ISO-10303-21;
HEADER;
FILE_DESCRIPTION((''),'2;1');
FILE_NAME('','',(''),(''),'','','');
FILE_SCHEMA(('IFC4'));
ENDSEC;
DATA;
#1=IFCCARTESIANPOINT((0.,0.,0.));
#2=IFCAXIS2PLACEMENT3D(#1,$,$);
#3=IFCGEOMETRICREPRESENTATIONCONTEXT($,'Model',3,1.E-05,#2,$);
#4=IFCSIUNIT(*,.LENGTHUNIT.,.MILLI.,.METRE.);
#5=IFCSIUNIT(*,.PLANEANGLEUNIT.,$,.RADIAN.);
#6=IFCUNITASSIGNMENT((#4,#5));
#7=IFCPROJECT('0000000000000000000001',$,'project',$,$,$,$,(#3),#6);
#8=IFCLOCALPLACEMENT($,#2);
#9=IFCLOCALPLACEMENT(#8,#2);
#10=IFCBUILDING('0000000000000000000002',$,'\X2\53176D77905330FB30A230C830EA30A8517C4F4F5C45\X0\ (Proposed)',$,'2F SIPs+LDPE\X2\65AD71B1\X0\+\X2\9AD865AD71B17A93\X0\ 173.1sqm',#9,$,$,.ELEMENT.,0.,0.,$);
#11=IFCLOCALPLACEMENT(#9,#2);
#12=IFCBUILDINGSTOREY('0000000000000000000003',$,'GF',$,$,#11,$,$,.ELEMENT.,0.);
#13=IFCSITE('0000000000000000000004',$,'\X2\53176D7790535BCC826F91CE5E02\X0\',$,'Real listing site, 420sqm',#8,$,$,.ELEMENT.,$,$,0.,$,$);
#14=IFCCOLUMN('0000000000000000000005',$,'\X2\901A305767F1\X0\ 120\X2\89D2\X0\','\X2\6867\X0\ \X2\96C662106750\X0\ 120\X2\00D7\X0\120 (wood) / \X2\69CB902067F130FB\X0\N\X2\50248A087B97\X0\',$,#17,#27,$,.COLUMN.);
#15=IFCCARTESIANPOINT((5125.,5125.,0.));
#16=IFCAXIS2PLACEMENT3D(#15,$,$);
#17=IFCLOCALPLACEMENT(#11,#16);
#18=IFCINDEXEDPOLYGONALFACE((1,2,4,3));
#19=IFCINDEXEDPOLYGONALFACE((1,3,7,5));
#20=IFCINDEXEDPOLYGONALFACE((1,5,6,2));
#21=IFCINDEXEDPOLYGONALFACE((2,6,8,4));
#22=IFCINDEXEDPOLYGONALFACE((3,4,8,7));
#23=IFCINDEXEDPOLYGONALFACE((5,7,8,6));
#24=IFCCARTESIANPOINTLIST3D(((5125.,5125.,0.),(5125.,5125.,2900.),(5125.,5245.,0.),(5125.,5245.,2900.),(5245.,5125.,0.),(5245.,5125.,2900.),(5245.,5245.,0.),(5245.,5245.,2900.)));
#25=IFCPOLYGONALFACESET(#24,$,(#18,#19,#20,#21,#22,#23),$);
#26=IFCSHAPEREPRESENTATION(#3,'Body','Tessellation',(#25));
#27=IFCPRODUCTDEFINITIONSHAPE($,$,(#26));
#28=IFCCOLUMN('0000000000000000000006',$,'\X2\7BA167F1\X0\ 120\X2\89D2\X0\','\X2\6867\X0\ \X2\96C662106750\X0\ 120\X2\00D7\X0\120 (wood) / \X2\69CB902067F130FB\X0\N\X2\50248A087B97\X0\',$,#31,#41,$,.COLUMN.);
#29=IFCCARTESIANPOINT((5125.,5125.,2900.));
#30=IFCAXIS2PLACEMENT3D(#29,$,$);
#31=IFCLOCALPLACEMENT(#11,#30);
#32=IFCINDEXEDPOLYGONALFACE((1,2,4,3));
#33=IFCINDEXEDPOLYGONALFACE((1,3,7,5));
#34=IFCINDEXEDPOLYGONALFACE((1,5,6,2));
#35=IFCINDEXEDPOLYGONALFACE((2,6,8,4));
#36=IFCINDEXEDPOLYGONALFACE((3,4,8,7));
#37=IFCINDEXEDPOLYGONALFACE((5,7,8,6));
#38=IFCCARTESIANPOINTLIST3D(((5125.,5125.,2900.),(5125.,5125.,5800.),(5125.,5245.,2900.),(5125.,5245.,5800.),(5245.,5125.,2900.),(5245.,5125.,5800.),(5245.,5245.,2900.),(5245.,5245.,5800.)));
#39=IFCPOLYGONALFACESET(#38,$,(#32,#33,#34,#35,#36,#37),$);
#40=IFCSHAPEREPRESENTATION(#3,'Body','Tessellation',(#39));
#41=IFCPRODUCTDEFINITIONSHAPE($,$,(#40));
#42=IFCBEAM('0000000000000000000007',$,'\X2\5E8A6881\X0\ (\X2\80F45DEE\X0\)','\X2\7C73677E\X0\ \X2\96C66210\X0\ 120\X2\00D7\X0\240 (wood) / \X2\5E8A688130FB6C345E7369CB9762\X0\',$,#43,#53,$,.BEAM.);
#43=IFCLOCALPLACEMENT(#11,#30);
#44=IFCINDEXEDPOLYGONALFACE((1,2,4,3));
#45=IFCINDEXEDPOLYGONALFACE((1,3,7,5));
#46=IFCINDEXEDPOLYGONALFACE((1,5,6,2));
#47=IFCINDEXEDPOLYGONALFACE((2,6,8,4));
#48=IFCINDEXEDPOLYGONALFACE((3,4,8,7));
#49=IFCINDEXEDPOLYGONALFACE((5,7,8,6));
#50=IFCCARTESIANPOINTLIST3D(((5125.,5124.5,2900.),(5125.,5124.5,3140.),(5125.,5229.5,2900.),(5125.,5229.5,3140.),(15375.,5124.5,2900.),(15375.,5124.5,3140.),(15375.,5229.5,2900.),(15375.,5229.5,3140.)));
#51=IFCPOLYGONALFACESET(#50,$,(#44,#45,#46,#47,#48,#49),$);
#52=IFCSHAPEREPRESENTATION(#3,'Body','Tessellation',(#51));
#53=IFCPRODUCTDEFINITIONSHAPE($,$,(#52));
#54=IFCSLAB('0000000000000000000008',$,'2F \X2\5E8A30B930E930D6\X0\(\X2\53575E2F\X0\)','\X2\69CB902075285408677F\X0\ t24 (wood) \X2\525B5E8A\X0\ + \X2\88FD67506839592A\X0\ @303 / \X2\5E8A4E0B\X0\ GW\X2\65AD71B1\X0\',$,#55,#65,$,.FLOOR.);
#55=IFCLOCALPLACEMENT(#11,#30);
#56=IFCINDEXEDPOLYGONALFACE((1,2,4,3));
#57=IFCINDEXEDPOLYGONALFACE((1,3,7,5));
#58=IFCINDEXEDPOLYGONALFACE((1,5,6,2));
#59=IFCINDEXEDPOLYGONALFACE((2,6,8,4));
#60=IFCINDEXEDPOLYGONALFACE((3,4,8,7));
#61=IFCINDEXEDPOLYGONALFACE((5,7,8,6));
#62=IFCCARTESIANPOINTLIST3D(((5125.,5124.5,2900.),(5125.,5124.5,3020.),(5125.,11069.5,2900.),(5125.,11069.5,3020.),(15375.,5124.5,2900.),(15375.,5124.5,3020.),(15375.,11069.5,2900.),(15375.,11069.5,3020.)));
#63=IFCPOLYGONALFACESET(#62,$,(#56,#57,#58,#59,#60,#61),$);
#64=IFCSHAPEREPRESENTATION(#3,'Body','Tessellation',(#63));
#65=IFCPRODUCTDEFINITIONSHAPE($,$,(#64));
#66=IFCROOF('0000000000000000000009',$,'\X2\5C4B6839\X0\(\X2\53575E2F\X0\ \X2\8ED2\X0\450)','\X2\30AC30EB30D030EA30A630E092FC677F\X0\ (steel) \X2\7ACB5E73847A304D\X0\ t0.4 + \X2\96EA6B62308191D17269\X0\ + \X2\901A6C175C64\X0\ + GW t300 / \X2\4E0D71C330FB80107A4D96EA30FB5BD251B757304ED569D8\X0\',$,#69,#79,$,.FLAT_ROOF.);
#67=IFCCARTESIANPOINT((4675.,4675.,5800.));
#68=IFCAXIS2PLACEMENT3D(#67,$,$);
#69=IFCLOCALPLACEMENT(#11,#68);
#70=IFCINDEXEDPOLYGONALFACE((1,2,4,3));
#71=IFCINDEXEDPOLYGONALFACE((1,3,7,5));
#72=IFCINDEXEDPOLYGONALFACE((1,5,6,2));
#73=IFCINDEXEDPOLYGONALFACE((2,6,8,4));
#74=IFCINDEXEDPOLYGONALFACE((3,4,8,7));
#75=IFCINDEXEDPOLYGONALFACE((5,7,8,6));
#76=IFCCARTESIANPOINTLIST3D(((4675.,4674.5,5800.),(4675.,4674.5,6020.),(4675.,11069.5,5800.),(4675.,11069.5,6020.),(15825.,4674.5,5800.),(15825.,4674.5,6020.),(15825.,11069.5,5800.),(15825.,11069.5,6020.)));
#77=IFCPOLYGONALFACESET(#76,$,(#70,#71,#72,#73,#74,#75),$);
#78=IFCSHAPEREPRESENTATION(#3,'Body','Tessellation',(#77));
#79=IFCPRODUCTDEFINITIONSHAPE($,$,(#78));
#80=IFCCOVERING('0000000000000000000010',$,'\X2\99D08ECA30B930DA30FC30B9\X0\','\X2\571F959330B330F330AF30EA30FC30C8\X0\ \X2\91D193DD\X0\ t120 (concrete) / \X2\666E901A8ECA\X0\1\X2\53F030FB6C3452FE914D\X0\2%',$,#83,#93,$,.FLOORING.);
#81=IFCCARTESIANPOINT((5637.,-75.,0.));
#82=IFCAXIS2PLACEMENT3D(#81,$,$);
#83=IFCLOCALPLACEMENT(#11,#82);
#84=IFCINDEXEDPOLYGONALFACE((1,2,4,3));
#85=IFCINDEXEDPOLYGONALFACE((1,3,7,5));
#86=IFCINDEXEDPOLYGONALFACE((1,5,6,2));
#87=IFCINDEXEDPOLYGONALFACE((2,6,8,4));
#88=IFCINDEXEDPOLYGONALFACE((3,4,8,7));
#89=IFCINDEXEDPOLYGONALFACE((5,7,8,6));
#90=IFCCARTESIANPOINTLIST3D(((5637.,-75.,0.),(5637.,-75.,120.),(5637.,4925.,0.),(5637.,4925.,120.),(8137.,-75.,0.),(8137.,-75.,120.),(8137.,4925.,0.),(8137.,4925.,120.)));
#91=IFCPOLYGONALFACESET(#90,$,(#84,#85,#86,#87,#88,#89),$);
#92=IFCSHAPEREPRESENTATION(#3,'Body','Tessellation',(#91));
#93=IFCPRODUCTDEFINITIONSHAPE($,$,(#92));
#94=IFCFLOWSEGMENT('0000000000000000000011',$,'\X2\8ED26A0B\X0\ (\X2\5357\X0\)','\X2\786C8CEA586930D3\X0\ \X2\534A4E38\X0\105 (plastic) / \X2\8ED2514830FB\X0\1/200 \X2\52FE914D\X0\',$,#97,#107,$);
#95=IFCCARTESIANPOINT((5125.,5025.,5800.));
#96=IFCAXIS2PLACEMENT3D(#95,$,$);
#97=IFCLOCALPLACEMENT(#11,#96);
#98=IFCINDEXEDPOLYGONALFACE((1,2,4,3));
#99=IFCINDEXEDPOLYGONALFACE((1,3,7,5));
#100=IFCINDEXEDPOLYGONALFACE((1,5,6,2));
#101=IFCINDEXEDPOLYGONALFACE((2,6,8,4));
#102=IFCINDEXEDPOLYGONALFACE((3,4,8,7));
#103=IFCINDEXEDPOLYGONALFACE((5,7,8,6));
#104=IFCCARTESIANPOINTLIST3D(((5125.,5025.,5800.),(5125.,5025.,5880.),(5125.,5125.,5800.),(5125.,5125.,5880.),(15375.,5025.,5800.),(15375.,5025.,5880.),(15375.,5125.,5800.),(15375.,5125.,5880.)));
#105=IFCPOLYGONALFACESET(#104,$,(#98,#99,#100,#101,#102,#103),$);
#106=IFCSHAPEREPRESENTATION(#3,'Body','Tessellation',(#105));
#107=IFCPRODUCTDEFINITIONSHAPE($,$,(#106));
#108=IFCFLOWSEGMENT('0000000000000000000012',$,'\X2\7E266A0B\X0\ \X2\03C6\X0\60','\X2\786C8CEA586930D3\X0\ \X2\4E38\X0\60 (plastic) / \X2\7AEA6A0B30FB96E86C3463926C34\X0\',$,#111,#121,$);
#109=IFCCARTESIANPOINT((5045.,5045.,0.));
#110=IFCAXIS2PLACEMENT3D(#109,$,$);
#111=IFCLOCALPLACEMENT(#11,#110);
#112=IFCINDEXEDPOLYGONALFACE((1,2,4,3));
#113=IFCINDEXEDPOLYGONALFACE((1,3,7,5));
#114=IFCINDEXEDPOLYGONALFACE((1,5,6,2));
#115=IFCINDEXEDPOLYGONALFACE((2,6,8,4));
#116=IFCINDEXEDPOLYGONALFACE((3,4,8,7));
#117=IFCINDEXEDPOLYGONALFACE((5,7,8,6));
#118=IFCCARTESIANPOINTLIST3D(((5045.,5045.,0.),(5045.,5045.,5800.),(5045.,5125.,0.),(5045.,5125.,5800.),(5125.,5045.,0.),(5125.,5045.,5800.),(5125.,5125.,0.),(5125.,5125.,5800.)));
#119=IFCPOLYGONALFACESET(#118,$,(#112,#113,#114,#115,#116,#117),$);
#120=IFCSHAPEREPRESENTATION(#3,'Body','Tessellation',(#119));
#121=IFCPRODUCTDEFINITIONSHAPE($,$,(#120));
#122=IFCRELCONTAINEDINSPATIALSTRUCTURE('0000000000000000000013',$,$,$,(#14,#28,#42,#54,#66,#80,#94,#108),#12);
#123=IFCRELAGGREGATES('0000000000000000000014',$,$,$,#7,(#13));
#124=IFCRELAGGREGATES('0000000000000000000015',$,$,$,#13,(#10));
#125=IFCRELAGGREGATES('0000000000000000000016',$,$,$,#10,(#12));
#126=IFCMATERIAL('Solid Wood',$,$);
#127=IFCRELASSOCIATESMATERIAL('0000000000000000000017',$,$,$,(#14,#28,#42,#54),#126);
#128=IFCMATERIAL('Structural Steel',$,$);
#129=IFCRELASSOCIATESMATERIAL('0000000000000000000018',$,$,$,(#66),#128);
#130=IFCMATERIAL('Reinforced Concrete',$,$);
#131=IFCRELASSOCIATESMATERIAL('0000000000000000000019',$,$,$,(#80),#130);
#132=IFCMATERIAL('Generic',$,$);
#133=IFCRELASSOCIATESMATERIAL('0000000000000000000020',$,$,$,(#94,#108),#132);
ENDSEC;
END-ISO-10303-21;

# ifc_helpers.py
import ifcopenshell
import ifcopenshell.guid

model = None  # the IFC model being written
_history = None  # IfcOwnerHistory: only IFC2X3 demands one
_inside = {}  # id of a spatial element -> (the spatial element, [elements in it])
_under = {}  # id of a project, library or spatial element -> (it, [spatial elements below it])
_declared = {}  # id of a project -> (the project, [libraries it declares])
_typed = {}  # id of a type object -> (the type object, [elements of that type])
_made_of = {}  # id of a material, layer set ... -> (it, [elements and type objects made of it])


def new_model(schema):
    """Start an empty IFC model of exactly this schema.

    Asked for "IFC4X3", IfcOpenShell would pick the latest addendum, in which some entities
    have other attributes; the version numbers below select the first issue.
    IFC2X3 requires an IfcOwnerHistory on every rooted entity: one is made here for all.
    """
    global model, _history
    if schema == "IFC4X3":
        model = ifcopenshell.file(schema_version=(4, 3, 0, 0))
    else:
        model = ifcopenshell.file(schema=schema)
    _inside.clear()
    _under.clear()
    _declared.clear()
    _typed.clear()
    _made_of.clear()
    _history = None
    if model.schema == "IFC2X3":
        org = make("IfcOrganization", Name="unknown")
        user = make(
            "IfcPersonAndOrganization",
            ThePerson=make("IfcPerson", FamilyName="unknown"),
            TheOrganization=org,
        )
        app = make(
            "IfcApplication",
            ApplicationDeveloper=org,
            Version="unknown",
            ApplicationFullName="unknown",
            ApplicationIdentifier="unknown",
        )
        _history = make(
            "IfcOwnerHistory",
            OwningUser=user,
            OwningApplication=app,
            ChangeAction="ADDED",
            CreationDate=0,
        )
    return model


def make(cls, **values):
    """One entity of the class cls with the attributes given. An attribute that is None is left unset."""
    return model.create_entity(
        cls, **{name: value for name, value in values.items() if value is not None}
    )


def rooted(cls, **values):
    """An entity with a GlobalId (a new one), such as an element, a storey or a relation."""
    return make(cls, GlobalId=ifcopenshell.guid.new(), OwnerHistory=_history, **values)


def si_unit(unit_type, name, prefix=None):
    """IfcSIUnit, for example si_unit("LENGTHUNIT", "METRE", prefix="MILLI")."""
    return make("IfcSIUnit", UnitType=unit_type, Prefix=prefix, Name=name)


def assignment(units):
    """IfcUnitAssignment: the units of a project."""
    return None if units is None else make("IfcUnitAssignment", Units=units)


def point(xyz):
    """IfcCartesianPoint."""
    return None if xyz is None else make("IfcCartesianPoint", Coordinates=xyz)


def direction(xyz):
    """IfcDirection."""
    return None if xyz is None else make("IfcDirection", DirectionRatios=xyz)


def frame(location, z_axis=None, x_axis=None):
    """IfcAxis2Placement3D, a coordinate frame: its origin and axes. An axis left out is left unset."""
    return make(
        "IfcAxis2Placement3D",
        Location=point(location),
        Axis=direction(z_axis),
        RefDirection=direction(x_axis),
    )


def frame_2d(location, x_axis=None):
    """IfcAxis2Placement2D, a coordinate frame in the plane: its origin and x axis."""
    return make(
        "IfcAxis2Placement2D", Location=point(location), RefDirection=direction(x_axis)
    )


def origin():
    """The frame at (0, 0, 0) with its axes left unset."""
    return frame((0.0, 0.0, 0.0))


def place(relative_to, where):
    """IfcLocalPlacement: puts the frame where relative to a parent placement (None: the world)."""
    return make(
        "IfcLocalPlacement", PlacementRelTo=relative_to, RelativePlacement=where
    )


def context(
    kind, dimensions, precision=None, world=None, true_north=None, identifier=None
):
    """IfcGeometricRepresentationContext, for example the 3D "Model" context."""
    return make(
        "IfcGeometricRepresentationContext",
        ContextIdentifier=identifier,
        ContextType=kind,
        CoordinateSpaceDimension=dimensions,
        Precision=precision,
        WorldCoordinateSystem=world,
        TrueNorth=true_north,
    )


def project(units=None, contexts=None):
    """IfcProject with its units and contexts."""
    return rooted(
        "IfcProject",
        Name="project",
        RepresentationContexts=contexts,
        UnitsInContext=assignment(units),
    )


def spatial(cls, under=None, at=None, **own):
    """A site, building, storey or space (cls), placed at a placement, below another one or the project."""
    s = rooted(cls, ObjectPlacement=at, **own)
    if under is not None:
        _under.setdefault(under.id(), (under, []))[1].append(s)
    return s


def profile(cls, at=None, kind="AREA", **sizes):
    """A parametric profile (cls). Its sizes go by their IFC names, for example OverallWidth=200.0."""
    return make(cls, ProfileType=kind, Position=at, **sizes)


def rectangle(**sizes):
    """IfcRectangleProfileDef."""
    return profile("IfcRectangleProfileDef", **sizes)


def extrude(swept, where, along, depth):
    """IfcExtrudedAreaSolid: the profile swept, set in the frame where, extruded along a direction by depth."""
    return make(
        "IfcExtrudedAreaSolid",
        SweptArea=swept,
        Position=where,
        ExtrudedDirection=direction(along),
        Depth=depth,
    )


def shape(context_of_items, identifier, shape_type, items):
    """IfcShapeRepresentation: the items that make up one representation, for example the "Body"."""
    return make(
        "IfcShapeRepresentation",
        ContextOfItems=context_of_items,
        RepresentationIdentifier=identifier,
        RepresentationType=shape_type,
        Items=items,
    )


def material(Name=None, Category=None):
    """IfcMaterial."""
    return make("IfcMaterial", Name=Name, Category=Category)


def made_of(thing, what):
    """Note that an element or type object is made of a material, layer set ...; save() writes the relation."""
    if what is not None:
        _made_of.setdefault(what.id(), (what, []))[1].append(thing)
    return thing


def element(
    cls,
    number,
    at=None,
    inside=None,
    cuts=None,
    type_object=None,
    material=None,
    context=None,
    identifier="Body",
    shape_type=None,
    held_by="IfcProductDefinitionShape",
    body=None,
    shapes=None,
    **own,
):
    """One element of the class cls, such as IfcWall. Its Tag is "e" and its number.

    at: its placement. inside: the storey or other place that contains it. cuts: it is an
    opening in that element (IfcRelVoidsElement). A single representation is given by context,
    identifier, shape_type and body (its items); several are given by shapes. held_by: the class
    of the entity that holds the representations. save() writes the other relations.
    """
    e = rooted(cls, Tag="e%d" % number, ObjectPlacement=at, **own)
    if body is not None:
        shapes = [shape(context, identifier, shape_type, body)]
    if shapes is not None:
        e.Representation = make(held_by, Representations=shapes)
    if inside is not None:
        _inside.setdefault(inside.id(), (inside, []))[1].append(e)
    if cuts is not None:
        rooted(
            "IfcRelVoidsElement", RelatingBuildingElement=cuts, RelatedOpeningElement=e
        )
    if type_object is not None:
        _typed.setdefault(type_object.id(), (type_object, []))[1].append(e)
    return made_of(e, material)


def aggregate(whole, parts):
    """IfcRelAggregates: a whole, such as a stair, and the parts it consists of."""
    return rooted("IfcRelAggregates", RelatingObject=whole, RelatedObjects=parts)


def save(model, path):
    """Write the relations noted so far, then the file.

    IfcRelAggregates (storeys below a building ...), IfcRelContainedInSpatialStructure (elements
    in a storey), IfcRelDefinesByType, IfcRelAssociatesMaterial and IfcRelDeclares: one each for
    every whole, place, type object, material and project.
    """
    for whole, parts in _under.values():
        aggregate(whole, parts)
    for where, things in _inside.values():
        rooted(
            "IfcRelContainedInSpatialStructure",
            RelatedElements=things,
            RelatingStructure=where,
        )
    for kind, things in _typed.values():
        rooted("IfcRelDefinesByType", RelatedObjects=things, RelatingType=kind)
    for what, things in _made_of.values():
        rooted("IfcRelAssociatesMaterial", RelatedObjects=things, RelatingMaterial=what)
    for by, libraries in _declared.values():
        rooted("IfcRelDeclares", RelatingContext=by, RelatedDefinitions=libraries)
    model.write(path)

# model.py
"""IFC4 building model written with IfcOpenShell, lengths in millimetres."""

from ifc_helpers import new_model, si_unit, frame, frame_2d, origin, place, context, project, spatial, rectangle, extrude, material, element, save


model = new_model("IFC4")

# Units and contexts
model_context = context("Model", 3, precision=1e-05, world=origin())
ifc_project = project(units=[si_unit("LENGTHUNIT", "METRE", prefix="MILLI"), si_unit("PLANEANGLEUNIT", "RADIAN")], contexts=[model_context])

# Site, building, storey
site_placement = place(None, origin())
site = spatial("IfcSite", under=ifc_project, at=site_placement, Name="北海道富良野市", ObjectType="Real listing site, 420sqm", CompositionType="ELEMENT", RefElevation=0.0)
building_placement = place(site_placement, origin())
building = spatial("IfcBuilding", under=site, at=building_placement, Name="北海道・アトリエ兼住居 (Proposed)", ObjectType="2F SIPs+LDPE断熱+高断熱窓 173.1sqm", CompositionType="ELEMENT", ElevationOfRefHeight=0.0, ElevationOfTerrain=0.0)
storey_placement = place(building_placement, origin())
storey = spatial("IfcBuildingStorey", under=building, at=storey_placement, Name="GF", CompositionType="ELEMENT", Elevation=0.0)

# Columns
ifc_material_1 = material(Name="Solid Wood")
column_1_placement = place(storey_placement, frame((5125.0, 5125.0, 0.0)))
element("IfcColumn", 1, at=column_1_placement, inside=storey, material=ifc_material_1, Name="通し柱 120角", Description="桧 集成材 120×120 (wood) / 構造柱・N値計算", PredefinedType="COLUMN", context=model_context, shape_type="SweptSolid", body=[
    extrude(rectangle(XDim=120.0, YDim=120.0, at=frame_2d((60.0, 60.0))), frame((5125.0, 5125.0, 0.0)), (0.0, 0.0, 1.0), 2900.0),
])
column_2_placement = place(storey_placement, frame((5125.0, 5125.0, 2900.0)))
element("IfcColumn", 2, at=column_2_placement, inside=storey, material=ifc_material_1, Name="管柱 120角", Description="桧 集成材 120×120 (wood) / 構造柱・N値計算", PredefinedType="COLUMN", context=model_context, shape_type="SweptSolid", body=[
    extrude(rectangle(XDim=120.0, YDim=120.0, at=frame_2d((60.0, 60.0))), frame((5125.0, 5125.0, 2900.0)), (0.0, 0.0, 1.0), 2900.0),
])

# Beam
beam_1_placement = place(storey_placement, frame((5125.0, 5125.0, 2900.0)))
element("IfcBeam", 3, at=beam_1_placement, inside=storey, material=ifc_material_1, Name="床梁 (胴差)", Description="米松 集成 120×240 (wood) / 床梁・水平構面", PredefinedType="BEAM", context=model_context, shape_type="SweptSolid", body=[
    extrude(rectangle(XDim=10250.0, YDim=105.0, at=frame_2d((5125.0, 52.0))), frame((5125.0, 5125.0, 2900.0)), (0.0, 0.0, 1.0), 240.0),
])

# Slab
ifc_material_2 = material(Name="Reinforced Concrete")
slab_1_placement = place(storey_placement, frame((5125.0, 5125.0, 2900.0)))
element("IfcSlab", 4, at=slab_1_placement, inside=storey, material=ifc_material_1, Name="2F 床スラブ(南帯)", Description="構造用合板 t24 (wood) 剛床 + 製材根太 @303 / 床下 GW断熱", PredefinedType="FLOOR", context=model_context, shape_type="SweptSolid", body=[
    extrude(rectangle(XDim=10250.0, YDim=5945.0, at=frame_2d((5125.0, 2972.0))), frame((5125.0, 5125.0, 2900.0)), (0.0, 0.0, 1.0), 120.0),
])

# Roof
ifc_material_3 = material(Name="Structural Steel")
for number, where, name in (
    (5, (4675.0, 4675.0, 5800.0), "屋根(南帯 軒450)"),
):
    element("IfcRoof", number, at=place(storey_placement, frame(where)), inside=storey, material=ifc_material_3, Name=name, Description="ガルバリウム鋼板 (steel) 立平葺き t0.4 + 雪止め金物 + 通気層 + GW t300 / 不燃・耐積雪・寒冷地仕様", PredefinedType="FLAT_ROOF", context=model_context, shape_type="SweptSolid", body=[
        extrude(rectangle(XDim=11150.0, YDim=6395.0, at=frame_2d((5575.0, 3197.0))), frame((4675.0, 4675.0, 5800.0)), (0.0, 0.0, 1.0), 220.0),
    ])

# Covering
covering_placement = place(storey_placement, frame((5637.0, -75.0, 0.0)))
element("IfcCovering", 6, at=covering_placement, inside=storey, material=ifc_material_2, Name="駐車スペース", Description="土間コンクリート 金鏝 t120 (concrete) / 普通車1台・水勾配2%", PredefinedType="FLOORING", context=model_context, shape_type="SweptSolid", body=[
    extrude(rectangle(XDim=2500.0, YDim=5000.0, at=frame_2d((1250.0, 2500.0))), frame((5637.0, -75.0, 0.0)), (0.0, 0.0, 1.0), 120.0),
])

# Flow segments
ifc_material_4 = material(Name="Generic")
flow_segment_1_placement = place(storey_placement, frame((5125.0, 5025.0, 5800.0)))
element("IfcFlowSegment", 7, at=flow_segment_1_placement, inside=storey, material=ifc_material_4, Name="軒樋 (南)", Description="硬質塩ビ 半丸105 (plastic) / 軒先・1/200 勾配", context=model_context, shape_type="SweptSolid", body=[
    extrude(rectangle(XDim=10250.0, YDim=100.0, at=frame_2d((5125.0, 50.0))), frame((5125.0, 5025.0, 5800.0)), (0.0, 0.0, 1.0), 80.0),
])
flow_segment_2_placement = place(storey_placement, frame((5045.0, 5045.0, 0.0)))
element("IfcFlowSegment", 8, at=flow_segment_2_placement, inside=storey, material=ifc_material_4, Name="縦樋 φ60", Description="硬質塩ビ 丸60 (plastic) / 竪樋・雨水排水", context=model_context, shape_type="SweptSolid", body=[
    extrude(rectangle(XDim=80.0, YDim=80.0, at=frame_2d((40.0, 40.0))), frame((5045.0, 5045.0, 0.0)), (0.0, 0.0, 1.0), 5800.0),
])

save(model, "model.ifc")
